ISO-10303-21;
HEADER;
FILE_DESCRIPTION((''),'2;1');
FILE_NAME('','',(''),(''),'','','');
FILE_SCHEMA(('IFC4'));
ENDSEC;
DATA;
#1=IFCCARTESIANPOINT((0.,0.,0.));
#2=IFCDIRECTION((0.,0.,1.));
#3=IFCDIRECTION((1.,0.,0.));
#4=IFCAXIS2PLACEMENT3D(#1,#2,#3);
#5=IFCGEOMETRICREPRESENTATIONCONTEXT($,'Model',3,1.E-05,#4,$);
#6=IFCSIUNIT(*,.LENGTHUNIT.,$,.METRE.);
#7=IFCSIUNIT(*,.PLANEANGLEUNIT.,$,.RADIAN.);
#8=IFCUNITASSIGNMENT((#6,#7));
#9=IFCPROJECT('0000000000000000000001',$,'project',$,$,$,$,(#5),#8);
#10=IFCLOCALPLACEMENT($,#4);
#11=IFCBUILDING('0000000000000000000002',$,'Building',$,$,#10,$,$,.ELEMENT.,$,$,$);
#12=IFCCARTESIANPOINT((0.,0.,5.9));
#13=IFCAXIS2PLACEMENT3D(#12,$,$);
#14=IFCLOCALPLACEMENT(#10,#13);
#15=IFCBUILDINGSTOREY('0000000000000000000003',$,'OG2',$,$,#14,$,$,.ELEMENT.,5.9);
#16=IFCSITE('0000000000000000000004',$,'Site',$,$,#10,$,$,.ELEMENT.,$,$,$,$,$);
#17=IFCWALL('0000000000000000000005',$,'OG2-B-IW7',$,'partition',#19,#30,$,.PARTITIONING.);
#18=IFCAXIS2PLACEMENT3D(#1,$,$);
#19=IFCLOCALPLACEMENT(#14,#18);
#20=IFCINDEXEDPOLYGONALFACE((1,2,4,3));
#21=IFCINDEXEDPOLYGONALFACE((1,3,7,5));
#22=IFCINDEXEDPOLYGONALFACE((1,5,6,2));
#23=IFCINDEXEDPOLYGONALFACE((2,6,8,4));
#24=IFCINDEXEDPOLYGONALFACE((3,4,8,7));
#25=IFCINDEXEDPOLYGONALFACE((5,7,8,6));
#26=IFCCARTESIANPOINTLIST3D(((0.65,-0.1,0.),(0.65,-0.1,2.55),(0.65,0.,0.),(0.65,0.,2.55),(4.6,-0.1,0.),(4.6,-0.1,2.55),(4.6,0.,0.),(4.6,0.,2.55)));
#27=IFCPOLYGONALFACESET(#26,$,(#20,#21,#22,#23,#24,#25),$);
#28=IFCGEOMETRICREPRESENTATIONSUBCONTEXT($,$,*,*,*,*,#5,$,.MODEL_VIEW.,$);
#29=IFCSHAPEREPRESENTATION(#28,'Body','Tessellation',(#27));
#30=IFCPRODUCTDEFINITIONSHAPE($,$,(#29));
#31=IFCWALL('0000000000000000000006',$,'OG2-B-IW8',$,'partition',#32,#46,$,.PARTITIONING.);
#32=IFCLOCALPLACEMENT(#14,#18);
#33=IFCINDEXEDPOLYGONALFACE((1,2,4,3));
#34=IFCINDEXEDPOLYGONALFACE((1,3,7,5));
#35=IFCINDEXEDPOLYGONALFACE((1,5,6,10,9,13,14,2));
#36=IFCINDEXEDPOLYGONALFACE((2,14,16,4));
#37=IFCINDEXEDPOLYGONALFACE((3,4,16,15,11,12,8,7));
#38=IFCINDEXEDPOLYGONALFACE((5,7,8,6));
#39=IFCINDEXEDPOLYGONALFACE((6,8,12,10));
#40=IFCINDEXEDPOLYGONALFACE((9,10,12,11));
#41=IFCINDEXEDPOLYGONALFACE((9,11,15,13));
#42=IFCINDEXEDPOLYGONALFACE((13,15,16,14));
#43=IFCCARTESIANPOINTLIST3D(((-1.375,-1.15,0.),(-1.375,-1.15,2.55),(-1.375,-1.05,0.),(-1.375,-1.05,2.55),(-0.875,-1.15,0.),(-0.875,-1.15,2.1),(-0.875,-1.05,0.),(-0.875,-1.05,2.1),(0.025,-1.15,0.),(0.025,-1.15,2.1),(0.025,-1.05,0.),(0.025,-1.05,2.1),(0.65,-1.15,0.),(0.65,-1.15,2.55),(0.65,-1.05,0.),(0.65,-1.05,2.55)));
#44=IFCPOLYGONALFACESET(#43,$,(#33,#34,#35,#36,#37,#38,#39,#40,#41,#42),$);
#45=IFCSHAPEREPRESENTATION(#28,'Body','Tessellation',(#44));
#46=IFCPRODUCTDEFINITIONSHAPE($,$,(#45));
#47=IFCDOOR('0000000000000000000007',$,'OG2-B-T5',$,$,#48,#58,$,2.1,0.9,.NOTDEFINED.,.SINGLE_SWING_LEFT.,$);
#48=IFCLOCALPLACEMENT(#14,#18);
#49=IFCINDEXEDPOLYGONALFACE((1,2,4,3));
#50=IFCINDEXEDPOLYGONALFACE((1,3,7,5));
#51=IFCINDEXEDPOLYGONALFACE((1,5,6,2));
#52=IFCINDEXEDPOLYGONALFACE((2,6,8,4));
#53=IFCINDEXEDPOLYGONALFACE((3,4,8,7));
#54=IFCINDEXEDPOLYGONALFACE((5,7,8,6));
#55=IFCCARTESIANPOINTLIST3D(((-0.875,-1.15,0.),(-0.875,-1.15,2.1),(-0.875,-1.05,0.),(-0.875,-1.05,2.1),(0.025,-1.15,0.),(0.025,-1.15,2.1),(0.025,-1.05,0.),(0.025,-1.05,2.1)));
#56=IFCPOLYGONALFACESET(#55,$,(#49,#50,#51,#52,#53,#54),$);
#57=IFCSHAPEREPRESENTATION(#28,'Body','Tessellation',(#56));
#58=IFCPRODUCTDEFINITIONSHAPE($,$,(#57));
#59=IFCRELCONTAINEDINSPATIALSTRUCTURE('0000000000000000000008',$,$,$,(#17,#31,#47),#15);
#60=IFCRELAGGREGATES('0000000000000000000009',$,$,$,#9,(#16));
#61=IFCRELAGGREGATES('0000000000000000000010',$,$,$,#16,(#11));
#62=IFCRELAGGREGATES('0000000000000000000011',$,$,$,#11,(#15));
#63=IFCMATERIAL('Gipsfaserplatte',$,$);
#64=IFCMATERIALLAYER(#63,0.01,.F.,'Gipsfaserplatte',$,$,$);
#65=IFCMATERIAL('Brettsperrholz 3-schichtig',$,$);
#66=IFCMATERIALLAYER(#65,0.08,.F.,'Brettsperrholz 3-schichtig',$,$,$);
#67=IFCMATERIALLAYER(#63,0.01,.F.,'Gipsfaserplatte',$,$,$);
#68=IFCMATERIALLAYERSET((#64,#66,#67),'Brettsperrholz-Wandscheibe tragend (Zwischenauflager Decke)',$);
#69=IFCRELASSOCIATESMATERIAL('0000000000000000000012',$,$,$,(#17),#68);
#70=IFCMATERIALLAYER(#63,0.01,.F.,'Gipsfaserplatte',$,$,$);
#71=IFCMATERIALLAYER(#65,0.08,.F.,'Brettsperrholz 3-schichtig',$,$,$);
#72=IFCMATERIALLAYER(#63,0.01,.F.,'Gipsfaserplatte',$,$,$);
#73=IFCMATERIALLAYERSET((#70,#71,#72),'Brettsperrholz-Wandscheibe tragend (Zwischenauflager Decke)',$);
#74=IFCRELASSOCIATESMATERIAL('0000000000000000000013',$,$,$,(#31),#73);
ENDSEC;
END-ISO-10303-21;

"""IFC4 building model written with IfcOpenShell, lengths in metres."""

from ifc_helpers import new_model, si_unit, frame, frame_2d, origin, origin_with_axes, place, context, subcontext, project, spatial, rectangle, extrude, material, layer, layer_set, element, fill, save


model = new_model("IFC4")

# Units and contexts
model_context = context("Model", 3, precision=1e-05, world=origin_with_axes())
sub_context = subcontext(model_context, None, None, "MODEL_VIEW")
ifc_project = project(units=[si_unit("LENGTHUNIT", "METRE"), si_unit("PLANEANGLEUNIT", "RADIAN")], contexts=[model_context])

# Site, building, storey
placement = place(None, origin_with_axes())
site = spatial("IfcSite", under=ifc_project, at=placement, Name="Site", CompositionType="ELEMENT")
building = spatial("IfcBuilding", under=site, at=placement, Name="Building", CompositionType="ELEMENT")
storey_placement = place(placement, frame((0.0, 0.0, 5.9)))
storey = spatial("IfcBuildingStorey", under=building, at=storey_placement, Name="OG2", CompositionType="ELEMENT", Elevation=5.9)

# Shared definitions
ifc_material_1 = material(Name="Gipsfaserplatte")

# Wall
ifc_material_2 = material(Name="Brettsperrholz 3-schichtig")
ifc_layer_1 = layer(ifc_material_1, 0.01, ventilated=False, Name="Gipsfaserplatte")
ifc_layer_2 = layer(ifc_material_2, 0.08, ventilated=False, Name="Brettsperrholz 3-schichtig")
ifc_layer_3 = layer(ifc_material_1, 0.01, ventilated=False, Name="Gipsfaserplatte")
ifc_layer_set_1 = layer_set([ifc_layer_1, ifc_layer_2, ifc_layer_3], Name="Brettsperrholz-Wandscheibe tragend (Zwischenauflager Decke)")
wall_1_placement = place(storey_placement, frame((0.65, -0.05, 0.0), z_axis=(0.0, 0.0, 1.0), x_axis=(1.0, 0.0, 0.0)))
element("IfcWall", 1, at=wall_1_placement, inside=storey, material=ifc_layer_set_1, Name="OG2-B-IW7", ObjectType="partition", PredefinedType="PARTITIONING", context=sub_context, shape_type="SweptSolid", body=[
    extrude(rectangle(XDim=3.95, YDim=0.1, at=frame_2d((1.975, 0.0))), origin(), (0.0, 0.0, 1.0), 2.55),
])

# Wall, opening, door
ifc_layer_4 = layer(ifc_material_1, 0.01, ventilated=False, Name="Gipsfaserplatte")
ifc_layer_5 = layer(ifc_material_2, 0.08, ventilated=False, Name="Brettsperrholz 3-schichtig")
ifc_layer_6 = layer(ifc_material_1, 0.01, ventilated=False, Name="Gipsfaserplatte")
ifc_layer_set_2 = layer_set([ifc_layer_4, ifc_layer_5, ifc_layer_6], Name="Brettsperrholz-Wandscheibe tragend (Zwischenauflager Decke)")
wall_2_placement = place(storey_placement, frame((-1.375, -1.1, 0.0), z_axis=(0.0, 0.0, 1.0), x_axis=(1.0, 0.0, 0.0)))
wall_2 = element("IfcWall", 2, at=wall_2_placement, inside=storey, material=ifc_layer_set_2, Name="OG2-B-IW8", ObjectType="partition", PredefinedType="PARTITIONING", context=sub_context, shape_type="SweptSolid", body=[
    extrude(rectangle(XDim=2.025, YDim=0.1, at=frame_2d((1.0125, 0.0))), origin(), (0.0, 0.0, 1.0), 2.55),
])
opening_1_placement = place(wall_2_placement, frame((0.95, 0.1, 0.0), z_axis=(0.0, -1.0, 0.0), x_axis=(1.0, 0.0, 0.0)))
opening_1 = element("IfcOpeningElement", 3, at=opening_1_placement, cuts=wall_2, PredefinedType="OPENING", context=sub_context, shape_type="SweptSolid", body=[
    extrude(rectangle(XDim=0.9, YDim=2.1, at=frame_2d((0.0, 1.05))), origin(), (0.0, 0.0, 1.0), 0.2),
])
door_1_placement = place(wall_2_placement, frame((0.95, 0.05, 0.0), z_axis=(0.0, -1.0, 0.0), x_axis=(1.0, 0.0, 0.0)))
door_1 = element("IfcDoor", 4, at=door_1_placement, inside=storey, Name="OG2-B-T5", OperationType="SINGLE_SWING_LEFT", OverallHeight=2.1, OverallWidth=0.9, PredefinedType="NOTDEFINED", context=sub_context, shape_type="SweptSolid", body=[
    extrude(rectangle(XDim=0.9, YDim=2.1, at=frame_2d((0.0, 1.05))), origin(), (0.0, 0.0, 1.0), 0.1),
])
fill(opening_1, door_1)

save(model, "model.ifc")
